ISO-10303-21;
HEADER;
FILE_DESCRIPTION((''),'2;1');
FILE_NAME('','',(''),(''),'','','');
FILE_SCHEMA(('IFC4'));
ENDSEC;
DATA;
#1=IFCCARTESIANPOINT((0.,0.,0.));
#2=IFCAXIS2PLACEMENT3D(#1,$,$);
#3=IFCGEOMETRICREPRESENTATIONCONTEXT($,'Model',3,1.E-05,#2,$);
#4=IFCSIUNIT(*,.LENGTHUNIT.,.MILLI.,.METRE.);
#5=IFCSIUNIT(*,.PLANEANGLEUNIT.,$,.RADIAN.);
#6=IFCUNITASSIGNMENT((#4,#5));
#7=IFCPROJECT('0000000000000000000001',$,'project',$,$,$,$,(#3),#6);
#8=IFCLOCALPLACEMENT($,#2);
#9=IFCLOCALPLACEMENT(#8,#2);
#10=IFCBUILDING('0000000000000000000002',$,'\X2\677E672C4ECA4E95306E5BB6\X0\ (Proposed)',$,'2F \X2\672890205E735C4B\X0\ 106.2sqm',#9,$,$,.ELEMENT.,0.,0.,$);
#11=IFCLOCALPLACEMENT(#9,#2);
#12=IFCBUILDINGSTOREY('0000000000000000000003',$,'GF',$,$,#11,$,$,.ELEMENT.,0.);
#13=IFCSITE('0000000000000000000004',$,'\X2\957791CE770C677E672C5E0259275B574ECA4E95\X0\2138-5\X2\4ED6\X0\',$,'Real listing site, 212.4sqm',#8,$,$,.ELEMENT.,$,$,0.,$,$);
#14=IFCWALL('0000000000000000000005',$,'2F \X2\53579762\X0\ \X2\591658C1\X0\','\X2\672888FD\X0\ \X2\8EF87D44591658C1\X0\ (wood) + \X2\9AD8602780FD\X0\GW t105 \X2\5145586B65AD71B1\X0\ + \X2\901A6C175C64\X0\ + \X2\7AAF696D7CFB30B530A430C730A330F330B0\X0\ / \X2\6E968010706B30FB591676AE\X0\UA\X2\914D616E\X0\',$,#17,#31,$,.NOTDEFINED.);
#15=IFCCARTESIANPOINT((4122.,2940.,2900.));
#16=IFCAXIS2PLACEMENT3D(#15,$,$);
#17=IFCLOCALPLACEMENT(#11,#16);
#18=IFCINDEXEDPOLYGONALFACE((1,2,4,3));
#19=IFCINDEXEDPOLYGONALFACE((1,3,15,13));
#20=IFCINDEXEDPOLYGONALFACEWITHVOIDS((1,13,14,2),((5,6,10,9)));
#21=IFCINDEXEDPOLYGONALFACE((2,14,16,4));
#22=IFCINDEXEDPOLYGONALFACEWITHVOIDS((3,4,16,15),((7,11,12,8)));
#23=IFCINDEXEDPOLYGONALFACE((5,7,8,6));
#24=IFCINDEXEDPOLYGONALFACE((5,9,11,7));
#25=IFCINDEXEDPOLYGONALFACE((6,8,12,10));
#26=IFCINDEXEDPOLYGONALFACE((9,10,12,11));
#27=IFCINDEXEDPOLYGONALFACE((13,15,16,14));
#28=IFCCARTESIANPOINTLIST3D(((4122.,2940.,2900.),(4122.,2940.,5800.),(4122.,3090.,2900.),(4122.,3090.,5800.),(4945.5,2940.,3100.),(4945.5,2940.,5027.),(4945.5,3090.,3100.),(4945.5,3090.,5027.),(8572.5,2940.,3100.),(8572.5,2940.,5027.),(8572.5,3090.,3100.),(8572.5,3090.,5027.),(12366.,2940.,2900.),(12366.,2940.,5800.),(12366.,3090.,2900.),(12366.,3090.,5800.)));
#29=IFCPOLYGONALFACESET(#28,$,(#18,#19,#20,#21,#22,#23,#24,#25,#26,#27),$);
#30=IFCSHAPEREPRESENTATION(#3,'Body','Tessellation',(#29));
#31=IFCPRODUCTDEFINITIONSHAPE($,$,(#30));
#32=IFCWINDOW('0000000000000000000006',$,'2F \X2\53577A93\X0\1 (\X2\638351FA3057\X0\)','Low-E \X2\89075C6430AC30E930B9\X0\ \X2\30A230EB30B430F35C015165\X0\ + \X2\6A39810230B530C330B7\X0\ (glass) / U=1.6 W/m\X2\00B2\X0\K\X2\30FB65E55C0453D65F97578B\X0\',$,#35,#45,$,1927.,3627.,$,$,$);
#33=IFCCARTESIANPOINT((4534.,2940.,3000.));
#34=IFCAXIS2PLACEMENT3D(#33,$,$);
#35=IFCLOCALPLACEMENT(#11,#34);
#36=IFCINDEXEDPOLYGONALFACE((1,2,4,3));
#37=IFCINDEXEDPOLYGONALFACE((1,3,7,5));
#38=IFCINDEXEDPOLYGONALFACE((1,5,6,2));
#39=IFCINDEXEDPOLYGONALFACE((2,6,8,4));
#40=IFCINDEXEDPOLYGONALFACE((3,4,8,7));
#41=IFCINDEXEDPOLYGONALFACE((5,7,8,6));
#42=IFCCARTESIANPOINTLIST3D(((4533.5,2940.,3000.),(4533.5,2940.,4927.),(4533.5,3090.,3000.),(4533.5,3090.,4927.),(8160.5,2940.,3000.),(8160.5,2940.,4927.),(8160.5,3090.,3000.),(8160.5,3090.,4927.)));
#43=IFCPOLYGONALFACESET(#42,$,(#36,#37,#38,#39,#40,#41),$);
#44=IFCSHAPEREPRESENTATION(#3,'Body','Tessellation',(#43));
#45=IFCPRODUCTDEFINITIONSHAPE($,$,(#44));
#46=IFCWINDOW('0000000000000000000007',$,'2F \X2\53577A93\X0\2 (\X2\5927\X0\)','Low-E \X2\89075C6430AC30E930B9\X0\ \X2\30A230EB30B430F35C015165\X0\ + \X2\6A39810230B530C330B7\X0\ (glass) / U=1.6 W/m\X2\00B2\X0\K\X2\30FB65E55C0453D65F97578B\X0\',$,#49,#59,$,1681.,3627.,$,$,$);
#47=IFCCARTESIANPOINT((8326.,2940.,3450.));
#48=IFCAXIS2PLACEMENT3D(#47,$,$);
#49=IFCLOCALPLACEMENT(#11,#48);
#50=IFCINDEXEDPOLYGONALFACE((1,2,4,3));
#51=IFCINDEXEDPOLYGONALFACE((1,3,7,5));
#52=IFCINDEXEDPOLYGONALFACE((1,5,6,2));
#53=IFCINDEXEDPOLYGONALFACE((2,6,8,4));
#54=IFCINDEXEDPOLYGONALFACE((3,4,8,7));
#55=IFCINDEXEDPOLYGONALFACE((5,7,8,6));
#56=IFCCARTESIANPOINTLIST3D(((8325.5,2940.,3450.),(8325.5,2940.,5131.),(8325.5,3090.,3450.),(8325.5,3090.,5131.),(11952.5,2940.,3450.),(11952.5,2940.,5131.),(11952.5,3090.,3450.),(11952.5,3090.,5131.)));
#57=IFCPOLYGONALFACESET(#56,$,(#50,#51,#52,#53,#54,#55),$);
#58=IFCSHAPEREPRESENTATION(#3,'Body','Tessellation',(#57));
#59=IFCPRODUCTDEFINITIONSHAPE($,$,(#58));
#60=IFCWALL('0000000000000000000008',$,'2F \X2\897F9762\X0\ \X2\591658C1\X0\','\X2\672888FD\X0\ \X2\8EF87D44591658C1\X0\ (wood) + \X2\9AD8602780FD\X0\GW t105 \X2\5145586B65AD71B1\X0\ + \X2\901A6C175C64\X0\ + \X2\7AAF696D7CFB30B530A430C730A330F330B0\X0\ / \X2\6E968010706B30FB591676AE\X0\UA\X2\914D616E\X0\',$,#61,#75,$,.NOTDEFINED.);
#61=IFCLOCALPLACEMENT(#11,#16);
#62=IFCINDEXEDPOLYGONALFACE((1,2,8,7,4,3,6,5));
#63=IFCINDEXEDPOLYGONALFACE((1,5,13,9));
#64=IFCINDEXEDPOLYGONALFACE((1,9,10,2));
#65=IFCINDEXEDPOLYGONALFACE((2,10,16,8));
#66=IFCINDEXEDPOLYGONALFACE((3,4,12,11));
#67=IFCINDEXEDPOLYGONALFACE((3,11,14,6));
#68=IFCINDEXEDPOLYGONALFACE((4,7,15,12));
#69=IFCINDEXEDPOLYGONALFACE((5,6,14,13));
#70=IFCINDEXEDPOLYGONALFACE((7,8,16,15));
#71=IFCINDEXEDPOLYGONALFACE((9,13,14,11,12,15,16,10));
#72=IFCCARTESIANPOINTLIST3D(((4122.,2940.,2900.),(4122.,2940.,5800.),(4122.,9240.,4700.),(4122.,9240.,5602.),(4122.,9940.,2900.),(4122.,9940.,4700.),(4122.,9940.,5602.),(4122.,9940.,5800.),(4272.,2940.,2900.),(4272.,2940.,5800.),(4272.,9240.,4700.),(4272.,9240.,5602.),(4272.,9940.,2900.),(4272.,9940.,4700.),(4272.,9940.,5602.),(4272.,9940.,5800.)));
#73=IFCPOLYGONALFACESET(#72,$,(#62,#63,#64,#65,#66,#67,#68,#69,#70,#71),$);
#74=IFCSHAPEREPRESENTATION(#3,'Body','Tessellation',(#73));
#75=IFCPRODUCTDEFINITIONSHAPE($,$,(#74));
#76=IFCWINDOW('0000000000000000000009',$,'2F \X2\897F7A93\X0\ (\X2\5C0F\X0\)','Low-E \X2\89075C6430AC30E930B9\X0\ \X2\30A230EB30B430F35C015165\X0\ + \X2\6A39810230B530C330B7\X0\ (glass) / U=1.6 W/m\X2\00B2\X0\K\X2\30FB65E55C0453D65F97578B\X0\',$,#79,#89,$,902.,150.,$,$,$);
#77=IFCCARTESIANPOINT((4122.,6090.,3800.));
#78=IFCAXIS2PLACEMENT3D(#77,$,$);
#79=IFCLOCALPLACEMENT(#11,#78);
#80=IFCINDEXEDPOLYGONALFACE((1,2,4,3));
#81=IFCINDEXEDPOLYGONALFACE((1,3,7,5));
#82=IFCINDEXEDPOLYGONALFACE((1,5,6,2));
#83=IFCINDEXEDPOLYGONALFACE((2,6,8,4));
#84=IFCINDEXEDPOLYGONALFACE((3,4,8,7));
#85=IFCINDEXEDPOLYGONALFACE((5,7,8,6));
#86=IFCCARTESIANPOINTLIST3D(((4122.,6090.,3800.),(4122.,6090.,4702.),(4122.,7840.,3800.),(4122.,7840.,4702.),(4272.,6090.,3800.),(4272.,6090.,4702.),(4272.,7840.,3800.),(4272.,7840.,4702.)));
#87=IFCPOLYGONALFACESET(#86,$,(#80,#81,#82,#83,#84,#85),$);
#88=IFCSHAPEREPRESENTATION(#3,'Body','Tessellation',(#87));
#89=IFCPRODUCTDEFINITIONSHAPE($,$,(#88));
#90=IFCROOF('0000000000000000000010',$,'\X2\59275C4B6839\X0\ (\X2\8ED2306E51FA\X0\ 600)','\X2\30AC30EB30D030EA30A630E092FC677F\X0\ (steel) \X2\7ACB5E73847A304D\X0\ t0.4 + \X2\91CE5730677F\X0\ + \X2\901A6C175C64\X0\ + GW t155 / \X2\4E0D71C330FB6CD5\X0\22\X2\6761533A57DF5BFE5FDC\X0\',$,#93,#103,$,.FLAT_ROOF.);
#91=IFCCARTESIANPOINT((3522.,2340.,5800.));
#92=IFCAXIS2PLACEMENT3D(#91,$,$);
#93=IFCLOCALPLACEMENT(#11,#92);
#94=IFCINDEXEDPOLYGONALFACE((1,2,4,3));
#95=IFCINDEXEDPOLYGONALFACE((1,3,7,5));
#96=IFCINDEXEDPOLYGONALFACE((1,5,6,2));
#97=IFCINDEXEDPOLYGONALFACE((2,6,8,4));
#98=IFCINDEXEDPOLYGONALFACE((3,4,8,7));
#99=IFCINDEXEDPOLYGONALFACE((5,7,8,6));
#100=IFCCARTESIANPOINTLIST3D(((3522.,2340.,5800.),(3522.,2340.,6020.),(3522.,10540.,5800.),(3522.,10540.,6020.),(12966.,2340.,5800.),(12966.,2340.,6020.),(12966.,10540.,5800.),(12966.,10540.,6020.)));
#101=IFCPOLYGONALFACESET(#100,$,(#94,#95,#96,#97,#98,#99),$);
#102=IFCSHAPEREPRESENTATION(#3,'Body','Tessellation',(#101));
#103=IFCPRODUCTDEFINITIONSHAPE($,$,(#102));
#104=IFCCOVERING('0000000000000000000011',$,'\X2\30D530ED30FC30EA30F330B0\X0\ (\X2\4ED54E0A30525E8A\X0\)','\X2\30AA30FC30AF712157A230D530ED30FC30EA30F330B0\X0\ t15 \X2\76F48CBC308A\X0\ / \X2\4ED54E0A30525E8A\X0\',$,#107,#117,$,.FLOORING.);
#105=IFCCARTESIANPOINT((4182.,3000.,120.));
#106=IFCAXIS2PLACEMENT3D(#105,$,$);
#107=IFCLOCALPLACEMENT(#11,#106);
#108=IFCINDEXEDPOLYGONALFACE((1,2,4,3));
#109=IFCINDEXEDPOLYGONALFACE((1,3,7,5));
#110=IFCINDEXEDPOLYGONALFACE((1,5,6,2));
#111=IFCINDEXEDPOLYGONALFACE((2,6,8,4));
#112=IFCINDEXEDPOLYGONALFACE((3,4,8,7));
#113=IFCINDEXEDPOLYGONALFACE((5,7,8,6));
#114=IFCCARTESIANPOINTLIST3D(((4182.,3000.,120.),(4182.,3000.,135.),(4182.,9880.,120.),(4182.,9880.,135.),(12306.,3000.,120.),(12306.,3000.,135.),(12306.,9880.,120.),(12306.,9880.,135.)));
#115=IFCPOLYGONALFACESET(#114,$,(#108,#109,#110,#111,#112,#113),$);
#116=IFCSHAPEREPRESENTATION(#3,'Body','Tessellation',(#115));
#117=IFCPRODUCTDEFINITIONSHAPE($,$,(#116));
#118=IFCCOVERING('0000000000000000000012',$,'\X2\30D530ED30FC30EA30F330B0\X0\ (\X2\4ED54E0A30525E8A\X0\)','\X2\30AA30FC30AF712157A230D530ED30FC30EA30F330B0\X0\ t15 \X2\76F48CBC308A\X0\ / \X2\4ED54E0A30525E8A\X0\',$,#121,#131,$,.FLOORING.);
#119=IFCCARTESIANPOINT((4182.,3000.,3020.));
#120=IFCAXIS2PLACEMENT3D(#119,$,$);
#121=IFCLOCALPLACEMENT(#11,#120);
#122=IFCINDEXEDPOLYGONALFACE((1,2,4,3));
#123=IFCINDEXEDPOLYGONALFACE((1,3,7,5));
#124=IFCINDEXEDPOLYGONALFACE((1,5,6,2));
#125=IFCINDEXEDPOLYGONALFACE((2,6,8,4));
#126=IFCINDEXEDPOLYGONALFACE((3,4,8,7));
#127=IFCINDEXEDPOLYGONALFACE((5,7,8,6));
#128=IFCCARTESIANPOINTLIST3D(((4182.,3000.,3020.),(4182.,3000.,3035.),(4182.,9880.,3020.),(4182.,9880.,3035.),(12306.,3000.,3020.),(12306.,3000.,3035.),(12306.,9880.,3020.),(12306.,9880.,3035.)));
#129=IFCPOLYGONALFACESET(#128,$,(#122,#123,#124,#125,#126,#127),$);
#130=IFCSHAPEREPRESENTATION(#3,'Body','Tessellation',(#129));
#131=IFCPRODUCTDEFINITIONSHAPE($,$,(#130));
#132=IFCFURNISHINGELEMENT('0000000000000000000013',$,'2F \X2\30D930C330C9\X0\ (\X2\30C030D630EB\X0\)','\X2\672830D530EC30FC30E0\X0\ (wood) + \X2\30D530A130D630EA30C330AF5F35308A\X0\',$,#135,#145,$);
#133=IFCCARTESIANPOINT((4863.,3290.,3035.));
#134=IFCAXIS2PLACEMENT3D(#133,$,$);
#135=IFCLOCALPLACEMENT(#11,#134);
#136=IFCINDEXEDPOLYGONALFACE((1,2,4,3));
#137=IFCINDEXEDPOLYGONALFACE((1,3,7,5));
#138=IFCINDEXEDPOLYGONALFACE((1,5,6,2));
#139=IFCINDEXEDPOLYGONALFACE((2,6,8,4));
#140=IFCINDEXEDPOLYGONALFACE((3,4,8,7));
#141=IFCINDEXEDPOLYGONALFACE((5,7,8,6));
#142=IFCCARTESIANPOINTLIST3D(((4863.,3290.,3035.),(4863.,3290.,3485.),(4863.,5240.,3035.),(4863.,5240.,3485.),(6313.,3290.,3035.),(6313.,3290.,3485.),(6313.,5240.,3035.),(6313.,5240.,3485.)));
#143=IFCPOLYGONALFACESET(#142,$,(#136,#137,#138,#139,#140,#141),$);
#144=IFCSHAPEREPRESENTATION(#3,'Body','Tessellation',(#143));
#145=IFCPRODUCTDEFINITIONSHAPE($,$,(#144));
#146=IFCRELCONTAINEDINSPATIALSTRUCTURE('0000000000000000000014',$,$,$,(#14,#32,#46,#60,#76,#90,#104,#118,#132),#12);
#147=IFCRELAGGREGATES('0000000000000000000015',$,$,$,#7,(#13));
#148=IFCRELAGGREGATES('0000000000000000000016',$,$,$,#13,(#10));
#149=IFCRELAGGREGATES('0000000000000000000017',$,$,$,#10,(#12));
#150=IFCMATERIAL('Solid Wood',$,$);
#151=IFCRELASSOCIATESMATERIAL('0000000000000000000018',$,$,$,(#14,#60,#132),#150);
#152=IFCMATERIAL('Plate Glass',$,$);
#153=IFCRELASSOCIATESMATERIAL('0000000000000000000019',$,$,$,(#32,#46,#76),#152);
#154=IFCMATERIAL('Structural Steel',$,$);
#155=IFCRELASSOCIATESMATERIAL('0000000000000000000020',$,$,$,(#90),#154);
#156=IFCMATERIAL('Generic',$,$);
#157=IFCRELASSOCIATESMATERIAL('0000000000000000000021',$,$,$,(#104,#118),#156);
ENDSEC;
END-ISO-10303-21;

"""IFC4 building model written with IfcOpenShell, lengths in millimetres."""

from ifc_helpers import new_model, si_unit, frame, frame_2d, origin, place, context, project, spatial, rectangle, extrude, material, element, fill, save


model = new_model("IFC4")

# Units and contexts
model_context = context("Model", 3, precision=1e-05, world=origin())
ifc_project = project(units=[si_unit("LENGTHUNIT", "METRE", prefix="MILLI"), si_unit("PLANEANGLEUNIT", "RADIAN")], contexts=[model_context])

# Site, building, storey
site_placement = place(None, origin())
site = spatial("IfcSite", under=ifc_project, at=site_placement, Name="長野県松本市大字今井2138-5他", ObjectType="Real listing site, 212.4sqm", CompositionType="ELEMENT", RefElevation=0.0)
building_placement = place(site_placement, origin())
building = spatial("IfcBuilding", under=site, at=building_placement, Name="松本今井の家 (Proposed)", ObjectType="2F 木造平屋 106.2sqm", CompositionType="ELEMENT", ElevationOfRefHeight=0.0, ElevationOfTerrain=0.0)
storey_placement = place(building_placement, origin())
storey = spatial("IfcBuildingStorey", under=building, at=storey_placement, Name="GF", CompositionType="ELEMENT", Elevation=0.0)

# Shared definitions
ifc_material_1 = material(Name="Solid Wood")

# Shared definitions
ifc_material_2 = material(Name="Plate Glass")

# Wall, openings, windows
wall_1_placement = place(storey_placement, frame((4122.0, 2940.0, 2900.0)))
wall_1 = element("IfcWall", 1, at=wall_1_placement, inside=storey, material=ifc_material_1, Name="2F 南面 外壁", Description="木製 軸組外壁 (wood) + 高性能GW t105 充填断熱 + 通気層 + 窯業系サイディング / 準耐火・外皮UA配慮", PredefinedType="NOTDEFINED", context=model_context, shape_type="SweptSolid", body=[
    extrude(rectangle(XDim=8244.0, YDim=150.0, at=frame_2d((4122.0, 75.0))), frame((4122.0, 2940.0, 2900.0)), (0.0, 0.0, 1.0), 2900.0),
])
opening_1_placement = place(storey_placement, frame((4534.0, 2940.0, 3000.0)))
opening_1 = element("IfcOpeningElement", 2, at=opening_1_placement, cuts=wall_1, PredefinedType="NOTDEFINED", context=model_context, shape_type="SweptSolid", body=[
    extrude(rectangle(XDim=3627.0, YDim=150.0, at=frame_2d((1813.0, 75.0))), frame((4534.0, 2940.0, 3000.0)), (0.0, 0.0, 1.0), 1927.0),
])
opening_2_placement = place(storey_placement, frame((8326.0, 2940.0, 3450.0)))
opening_2 = element("IfcOpeningElement", 3, at=opening_2_placement, cuts=wall_1, PredefinedType="NOTDEFINED", context=model_context, shape_type="SweptSolid", body=[
    extrude(rectangle(XDim=3627.0, YDim=150.0, at=frame_2d((1813.0, 75.0))), frame((8326.0, 2940.0, 3450.0)), (0.0, 0.0, 1.0), 1681.0),
])
window_1_placement = place(storey_placement, frame((4534.0, 2940.0, 3000.0)))
window_1 = element("IfcWindow", 4, at=window_1_placement, inside=storey, material=ifc_material_2, Name="2F 南窓1 (掃出し)", Description="Low-E 複層ガラス アルゴン封入 + 樹脂サッシ (glass) / U=1.6 W/m²K・日射取得型", OverallHeight=1927.0, OverallWidth=3627.0, context=model_context, shape_type="SweptSolid", body=[
    extrude(rectangle(XDim=3627.0, YDim=150.0, at=frame_2d((1813.0, 75.0))), frame((4534.0, 2940.0, 3000.0)), (0.0, 0.0, 1.0), 1927.0),
])
fill(opening_1, window_1)
window_2_placement = place(storey_placement, frame((8326.0, 2940.0, 3450.0)))
window_2 = element("IfcWindow", 5, at=window_2_placement, inside=storey, material=ifc_material_2, Name="2F 南窓2 (大)", Description="Low-E 複層ガラス アルゴン封入 + 樹脂サッシ (glass) / U=1.6 W/m²K・日射取得型", OverallHeight=1681.0, OverallWidth=3627.0, context=model_context, shape_type="SweptSolid", body=[
    extrude(rectangle(XDim=3627.0, YDim=150.0, at=frame_2d((1813.0, 75.0))), frame((8326.0, 2940.0, 3450.0)), (0.0, 0.0, 1.0), 1681.0),
])
fill(opening_2, window_2)

# Wall, opening, window
wall_2_placement = place(storey_placement, frame((4122.0, 2940.0, 2900.0)))
wall_2 = element("IfcWall", 6, at=wall_2_placement, inside=storey, material=ifc_material_1, Name="2F 西面 外壁", Description="木製 軸組外壁 (wood) + 高性能GW t105 充填断熱 + 通気層 + 窯業系サイディング / 準耐火・外皮UA配慮", PredefinedType="NOTDEFINED", context=model_context, shape_type="SweptSolid", body=[
    extrude(rectangle(XDim=150.0, YDim=7000.0, at=frame_2d((75.0, 3500.0))), frame((4122.0, 2940.0, 2900.0)), (0.0, 0.0, 1.0), 2900.0),
])
opening_3_placement = place(storey_placement, frame((4122.0, 6090.0, 3800.0)))
opening_3 = element("IfcOpeningElement", 7, at=opening_3_placement, cuts=wall_2, PredefinedType="NOTDEFINED", context=model_context, shape_type="SweptSolid", body=[
    extrude(rectangle(XDim=150.0, YDim=1750.0, at=frame_2d((75.0, 875.0))), frame((4122.0, 6090.0, 3800.0)), (0.0, 0.0, 1.0), 902.0),
])
window_3_placement = place(storey_placement, frame((4122.0, 6090.0, 3800.0)))
window_3 = element("IfcWindow", 8, at=window_3_placement, inside=storey, material=ifc_material_2, Name="2F 西窓 (小)", Description="Low-E 複層ガラス アルゴン封入 + 樹脂サッシ (glass) / U=1.6 W/m²K・日射取得型", OverallHeight=902.0, OverallWidth=150.0, context=model_context, shape_type="SweptSolid", body=[
    extrude(rectangle(XDim=150.0, YDim=1750.0, at=frame_2d((75.0, 875.0))), frame((4122.0, 6090.0, 3800.0)), (0.0, 0.0, 1.0), 902.0),
])
fill(opening_3, window_3)

# Roof
ifc_material_3 = material(Name="Structural Steel")
roof_placement = place(storey_placement, frame((3522.0, 2340.0, 5800.0)))
element("IfcRoof", 9, at=roof_placement, inside=storey, material=ifc_material_3, Name="大屋根 (軒の出 600)", Description="ガルバリウム鋼板 (steel) 立平葺き t0.4 + 野地板 + 通気層 + GW t155 / 不燃・法22条区域対応", PredefinedType="FLAT_ROOF", context=model_context, shape_type="SweptSolid", body=[
    extrude(rectangle(XDim=9444.0, YDim=8200.0, at=frame_2d((4722.0, 4100.0))), frame((3522.0, 2340.0, 5800.0)), (0.0, 0.0, 1.0), 220.0),
])

# Coverings
ifc_material_4 = material(Name="Generic")
covering_1_placement = place(storey_placement, frame((4182.0, 3000.0, 120.0)))
element("IfcCovering", 10, at=covering_1_placement, inside=storey, material=ifc_material_4, Name="フローリング (仕上げ床)", Description="オーク無垢フローリング t15 直貼り / 仕上げ床", PredefinedType="FLOORING", context=model_context, shape_type="SweptSolid", body=[
    extrude(rectangle(XDim=8124.0, YDim=6880.0, at=frame_2d((4062.0, 3440.0))), frame((4182.0, 3000.0, 120.0)), (0.0, 0.0, 1.0), 15.0),
])
covering_2_placement = place(storey_placement, frame((4182.0, 3000.0, 3020.0)))
element("IfcCovering", 11, at=covering_2_placement, inside=storey, material=ifc_material_4, Name="フローリング (仕上げ床)", Description="オーク無垢フローリング t15 直貼り / 仕上げ床", PredefinedType="FLOORING", context=model_context, shape_type="SweptSolid", body=[
    extrude(rectangle(XDim=8124.0, YDim=6880.0, at=frame_2d((4062.0, 3440.0))), frame((4182.0, 3000.0, 3020.0)), (0.0, 0.0, 1.0), 15.0),
])

# Furnishing element
furnishing_placement = place(storey_placement, frame((4863.0, 3290.0, 3035.0)))
element("IfcFurnishingElement", 12, at=furnishing_placement, inside=storey, material=ifc_material_1, Name="2F ベッド (ダブル)", Description="木フレーム (wood) + ファブリック張り", context=model_context, shape_type="SweptSolid", body=[
    extrude(rectangle(XDim=1450.0, YDim=1950.0, at=frame_2d((725.0, 975.0))), frame((4863.0, 3290.0, 3035.0)), (0.0, 0.0, 1.0), 450.0),
])

save(model, "model.ifc")
